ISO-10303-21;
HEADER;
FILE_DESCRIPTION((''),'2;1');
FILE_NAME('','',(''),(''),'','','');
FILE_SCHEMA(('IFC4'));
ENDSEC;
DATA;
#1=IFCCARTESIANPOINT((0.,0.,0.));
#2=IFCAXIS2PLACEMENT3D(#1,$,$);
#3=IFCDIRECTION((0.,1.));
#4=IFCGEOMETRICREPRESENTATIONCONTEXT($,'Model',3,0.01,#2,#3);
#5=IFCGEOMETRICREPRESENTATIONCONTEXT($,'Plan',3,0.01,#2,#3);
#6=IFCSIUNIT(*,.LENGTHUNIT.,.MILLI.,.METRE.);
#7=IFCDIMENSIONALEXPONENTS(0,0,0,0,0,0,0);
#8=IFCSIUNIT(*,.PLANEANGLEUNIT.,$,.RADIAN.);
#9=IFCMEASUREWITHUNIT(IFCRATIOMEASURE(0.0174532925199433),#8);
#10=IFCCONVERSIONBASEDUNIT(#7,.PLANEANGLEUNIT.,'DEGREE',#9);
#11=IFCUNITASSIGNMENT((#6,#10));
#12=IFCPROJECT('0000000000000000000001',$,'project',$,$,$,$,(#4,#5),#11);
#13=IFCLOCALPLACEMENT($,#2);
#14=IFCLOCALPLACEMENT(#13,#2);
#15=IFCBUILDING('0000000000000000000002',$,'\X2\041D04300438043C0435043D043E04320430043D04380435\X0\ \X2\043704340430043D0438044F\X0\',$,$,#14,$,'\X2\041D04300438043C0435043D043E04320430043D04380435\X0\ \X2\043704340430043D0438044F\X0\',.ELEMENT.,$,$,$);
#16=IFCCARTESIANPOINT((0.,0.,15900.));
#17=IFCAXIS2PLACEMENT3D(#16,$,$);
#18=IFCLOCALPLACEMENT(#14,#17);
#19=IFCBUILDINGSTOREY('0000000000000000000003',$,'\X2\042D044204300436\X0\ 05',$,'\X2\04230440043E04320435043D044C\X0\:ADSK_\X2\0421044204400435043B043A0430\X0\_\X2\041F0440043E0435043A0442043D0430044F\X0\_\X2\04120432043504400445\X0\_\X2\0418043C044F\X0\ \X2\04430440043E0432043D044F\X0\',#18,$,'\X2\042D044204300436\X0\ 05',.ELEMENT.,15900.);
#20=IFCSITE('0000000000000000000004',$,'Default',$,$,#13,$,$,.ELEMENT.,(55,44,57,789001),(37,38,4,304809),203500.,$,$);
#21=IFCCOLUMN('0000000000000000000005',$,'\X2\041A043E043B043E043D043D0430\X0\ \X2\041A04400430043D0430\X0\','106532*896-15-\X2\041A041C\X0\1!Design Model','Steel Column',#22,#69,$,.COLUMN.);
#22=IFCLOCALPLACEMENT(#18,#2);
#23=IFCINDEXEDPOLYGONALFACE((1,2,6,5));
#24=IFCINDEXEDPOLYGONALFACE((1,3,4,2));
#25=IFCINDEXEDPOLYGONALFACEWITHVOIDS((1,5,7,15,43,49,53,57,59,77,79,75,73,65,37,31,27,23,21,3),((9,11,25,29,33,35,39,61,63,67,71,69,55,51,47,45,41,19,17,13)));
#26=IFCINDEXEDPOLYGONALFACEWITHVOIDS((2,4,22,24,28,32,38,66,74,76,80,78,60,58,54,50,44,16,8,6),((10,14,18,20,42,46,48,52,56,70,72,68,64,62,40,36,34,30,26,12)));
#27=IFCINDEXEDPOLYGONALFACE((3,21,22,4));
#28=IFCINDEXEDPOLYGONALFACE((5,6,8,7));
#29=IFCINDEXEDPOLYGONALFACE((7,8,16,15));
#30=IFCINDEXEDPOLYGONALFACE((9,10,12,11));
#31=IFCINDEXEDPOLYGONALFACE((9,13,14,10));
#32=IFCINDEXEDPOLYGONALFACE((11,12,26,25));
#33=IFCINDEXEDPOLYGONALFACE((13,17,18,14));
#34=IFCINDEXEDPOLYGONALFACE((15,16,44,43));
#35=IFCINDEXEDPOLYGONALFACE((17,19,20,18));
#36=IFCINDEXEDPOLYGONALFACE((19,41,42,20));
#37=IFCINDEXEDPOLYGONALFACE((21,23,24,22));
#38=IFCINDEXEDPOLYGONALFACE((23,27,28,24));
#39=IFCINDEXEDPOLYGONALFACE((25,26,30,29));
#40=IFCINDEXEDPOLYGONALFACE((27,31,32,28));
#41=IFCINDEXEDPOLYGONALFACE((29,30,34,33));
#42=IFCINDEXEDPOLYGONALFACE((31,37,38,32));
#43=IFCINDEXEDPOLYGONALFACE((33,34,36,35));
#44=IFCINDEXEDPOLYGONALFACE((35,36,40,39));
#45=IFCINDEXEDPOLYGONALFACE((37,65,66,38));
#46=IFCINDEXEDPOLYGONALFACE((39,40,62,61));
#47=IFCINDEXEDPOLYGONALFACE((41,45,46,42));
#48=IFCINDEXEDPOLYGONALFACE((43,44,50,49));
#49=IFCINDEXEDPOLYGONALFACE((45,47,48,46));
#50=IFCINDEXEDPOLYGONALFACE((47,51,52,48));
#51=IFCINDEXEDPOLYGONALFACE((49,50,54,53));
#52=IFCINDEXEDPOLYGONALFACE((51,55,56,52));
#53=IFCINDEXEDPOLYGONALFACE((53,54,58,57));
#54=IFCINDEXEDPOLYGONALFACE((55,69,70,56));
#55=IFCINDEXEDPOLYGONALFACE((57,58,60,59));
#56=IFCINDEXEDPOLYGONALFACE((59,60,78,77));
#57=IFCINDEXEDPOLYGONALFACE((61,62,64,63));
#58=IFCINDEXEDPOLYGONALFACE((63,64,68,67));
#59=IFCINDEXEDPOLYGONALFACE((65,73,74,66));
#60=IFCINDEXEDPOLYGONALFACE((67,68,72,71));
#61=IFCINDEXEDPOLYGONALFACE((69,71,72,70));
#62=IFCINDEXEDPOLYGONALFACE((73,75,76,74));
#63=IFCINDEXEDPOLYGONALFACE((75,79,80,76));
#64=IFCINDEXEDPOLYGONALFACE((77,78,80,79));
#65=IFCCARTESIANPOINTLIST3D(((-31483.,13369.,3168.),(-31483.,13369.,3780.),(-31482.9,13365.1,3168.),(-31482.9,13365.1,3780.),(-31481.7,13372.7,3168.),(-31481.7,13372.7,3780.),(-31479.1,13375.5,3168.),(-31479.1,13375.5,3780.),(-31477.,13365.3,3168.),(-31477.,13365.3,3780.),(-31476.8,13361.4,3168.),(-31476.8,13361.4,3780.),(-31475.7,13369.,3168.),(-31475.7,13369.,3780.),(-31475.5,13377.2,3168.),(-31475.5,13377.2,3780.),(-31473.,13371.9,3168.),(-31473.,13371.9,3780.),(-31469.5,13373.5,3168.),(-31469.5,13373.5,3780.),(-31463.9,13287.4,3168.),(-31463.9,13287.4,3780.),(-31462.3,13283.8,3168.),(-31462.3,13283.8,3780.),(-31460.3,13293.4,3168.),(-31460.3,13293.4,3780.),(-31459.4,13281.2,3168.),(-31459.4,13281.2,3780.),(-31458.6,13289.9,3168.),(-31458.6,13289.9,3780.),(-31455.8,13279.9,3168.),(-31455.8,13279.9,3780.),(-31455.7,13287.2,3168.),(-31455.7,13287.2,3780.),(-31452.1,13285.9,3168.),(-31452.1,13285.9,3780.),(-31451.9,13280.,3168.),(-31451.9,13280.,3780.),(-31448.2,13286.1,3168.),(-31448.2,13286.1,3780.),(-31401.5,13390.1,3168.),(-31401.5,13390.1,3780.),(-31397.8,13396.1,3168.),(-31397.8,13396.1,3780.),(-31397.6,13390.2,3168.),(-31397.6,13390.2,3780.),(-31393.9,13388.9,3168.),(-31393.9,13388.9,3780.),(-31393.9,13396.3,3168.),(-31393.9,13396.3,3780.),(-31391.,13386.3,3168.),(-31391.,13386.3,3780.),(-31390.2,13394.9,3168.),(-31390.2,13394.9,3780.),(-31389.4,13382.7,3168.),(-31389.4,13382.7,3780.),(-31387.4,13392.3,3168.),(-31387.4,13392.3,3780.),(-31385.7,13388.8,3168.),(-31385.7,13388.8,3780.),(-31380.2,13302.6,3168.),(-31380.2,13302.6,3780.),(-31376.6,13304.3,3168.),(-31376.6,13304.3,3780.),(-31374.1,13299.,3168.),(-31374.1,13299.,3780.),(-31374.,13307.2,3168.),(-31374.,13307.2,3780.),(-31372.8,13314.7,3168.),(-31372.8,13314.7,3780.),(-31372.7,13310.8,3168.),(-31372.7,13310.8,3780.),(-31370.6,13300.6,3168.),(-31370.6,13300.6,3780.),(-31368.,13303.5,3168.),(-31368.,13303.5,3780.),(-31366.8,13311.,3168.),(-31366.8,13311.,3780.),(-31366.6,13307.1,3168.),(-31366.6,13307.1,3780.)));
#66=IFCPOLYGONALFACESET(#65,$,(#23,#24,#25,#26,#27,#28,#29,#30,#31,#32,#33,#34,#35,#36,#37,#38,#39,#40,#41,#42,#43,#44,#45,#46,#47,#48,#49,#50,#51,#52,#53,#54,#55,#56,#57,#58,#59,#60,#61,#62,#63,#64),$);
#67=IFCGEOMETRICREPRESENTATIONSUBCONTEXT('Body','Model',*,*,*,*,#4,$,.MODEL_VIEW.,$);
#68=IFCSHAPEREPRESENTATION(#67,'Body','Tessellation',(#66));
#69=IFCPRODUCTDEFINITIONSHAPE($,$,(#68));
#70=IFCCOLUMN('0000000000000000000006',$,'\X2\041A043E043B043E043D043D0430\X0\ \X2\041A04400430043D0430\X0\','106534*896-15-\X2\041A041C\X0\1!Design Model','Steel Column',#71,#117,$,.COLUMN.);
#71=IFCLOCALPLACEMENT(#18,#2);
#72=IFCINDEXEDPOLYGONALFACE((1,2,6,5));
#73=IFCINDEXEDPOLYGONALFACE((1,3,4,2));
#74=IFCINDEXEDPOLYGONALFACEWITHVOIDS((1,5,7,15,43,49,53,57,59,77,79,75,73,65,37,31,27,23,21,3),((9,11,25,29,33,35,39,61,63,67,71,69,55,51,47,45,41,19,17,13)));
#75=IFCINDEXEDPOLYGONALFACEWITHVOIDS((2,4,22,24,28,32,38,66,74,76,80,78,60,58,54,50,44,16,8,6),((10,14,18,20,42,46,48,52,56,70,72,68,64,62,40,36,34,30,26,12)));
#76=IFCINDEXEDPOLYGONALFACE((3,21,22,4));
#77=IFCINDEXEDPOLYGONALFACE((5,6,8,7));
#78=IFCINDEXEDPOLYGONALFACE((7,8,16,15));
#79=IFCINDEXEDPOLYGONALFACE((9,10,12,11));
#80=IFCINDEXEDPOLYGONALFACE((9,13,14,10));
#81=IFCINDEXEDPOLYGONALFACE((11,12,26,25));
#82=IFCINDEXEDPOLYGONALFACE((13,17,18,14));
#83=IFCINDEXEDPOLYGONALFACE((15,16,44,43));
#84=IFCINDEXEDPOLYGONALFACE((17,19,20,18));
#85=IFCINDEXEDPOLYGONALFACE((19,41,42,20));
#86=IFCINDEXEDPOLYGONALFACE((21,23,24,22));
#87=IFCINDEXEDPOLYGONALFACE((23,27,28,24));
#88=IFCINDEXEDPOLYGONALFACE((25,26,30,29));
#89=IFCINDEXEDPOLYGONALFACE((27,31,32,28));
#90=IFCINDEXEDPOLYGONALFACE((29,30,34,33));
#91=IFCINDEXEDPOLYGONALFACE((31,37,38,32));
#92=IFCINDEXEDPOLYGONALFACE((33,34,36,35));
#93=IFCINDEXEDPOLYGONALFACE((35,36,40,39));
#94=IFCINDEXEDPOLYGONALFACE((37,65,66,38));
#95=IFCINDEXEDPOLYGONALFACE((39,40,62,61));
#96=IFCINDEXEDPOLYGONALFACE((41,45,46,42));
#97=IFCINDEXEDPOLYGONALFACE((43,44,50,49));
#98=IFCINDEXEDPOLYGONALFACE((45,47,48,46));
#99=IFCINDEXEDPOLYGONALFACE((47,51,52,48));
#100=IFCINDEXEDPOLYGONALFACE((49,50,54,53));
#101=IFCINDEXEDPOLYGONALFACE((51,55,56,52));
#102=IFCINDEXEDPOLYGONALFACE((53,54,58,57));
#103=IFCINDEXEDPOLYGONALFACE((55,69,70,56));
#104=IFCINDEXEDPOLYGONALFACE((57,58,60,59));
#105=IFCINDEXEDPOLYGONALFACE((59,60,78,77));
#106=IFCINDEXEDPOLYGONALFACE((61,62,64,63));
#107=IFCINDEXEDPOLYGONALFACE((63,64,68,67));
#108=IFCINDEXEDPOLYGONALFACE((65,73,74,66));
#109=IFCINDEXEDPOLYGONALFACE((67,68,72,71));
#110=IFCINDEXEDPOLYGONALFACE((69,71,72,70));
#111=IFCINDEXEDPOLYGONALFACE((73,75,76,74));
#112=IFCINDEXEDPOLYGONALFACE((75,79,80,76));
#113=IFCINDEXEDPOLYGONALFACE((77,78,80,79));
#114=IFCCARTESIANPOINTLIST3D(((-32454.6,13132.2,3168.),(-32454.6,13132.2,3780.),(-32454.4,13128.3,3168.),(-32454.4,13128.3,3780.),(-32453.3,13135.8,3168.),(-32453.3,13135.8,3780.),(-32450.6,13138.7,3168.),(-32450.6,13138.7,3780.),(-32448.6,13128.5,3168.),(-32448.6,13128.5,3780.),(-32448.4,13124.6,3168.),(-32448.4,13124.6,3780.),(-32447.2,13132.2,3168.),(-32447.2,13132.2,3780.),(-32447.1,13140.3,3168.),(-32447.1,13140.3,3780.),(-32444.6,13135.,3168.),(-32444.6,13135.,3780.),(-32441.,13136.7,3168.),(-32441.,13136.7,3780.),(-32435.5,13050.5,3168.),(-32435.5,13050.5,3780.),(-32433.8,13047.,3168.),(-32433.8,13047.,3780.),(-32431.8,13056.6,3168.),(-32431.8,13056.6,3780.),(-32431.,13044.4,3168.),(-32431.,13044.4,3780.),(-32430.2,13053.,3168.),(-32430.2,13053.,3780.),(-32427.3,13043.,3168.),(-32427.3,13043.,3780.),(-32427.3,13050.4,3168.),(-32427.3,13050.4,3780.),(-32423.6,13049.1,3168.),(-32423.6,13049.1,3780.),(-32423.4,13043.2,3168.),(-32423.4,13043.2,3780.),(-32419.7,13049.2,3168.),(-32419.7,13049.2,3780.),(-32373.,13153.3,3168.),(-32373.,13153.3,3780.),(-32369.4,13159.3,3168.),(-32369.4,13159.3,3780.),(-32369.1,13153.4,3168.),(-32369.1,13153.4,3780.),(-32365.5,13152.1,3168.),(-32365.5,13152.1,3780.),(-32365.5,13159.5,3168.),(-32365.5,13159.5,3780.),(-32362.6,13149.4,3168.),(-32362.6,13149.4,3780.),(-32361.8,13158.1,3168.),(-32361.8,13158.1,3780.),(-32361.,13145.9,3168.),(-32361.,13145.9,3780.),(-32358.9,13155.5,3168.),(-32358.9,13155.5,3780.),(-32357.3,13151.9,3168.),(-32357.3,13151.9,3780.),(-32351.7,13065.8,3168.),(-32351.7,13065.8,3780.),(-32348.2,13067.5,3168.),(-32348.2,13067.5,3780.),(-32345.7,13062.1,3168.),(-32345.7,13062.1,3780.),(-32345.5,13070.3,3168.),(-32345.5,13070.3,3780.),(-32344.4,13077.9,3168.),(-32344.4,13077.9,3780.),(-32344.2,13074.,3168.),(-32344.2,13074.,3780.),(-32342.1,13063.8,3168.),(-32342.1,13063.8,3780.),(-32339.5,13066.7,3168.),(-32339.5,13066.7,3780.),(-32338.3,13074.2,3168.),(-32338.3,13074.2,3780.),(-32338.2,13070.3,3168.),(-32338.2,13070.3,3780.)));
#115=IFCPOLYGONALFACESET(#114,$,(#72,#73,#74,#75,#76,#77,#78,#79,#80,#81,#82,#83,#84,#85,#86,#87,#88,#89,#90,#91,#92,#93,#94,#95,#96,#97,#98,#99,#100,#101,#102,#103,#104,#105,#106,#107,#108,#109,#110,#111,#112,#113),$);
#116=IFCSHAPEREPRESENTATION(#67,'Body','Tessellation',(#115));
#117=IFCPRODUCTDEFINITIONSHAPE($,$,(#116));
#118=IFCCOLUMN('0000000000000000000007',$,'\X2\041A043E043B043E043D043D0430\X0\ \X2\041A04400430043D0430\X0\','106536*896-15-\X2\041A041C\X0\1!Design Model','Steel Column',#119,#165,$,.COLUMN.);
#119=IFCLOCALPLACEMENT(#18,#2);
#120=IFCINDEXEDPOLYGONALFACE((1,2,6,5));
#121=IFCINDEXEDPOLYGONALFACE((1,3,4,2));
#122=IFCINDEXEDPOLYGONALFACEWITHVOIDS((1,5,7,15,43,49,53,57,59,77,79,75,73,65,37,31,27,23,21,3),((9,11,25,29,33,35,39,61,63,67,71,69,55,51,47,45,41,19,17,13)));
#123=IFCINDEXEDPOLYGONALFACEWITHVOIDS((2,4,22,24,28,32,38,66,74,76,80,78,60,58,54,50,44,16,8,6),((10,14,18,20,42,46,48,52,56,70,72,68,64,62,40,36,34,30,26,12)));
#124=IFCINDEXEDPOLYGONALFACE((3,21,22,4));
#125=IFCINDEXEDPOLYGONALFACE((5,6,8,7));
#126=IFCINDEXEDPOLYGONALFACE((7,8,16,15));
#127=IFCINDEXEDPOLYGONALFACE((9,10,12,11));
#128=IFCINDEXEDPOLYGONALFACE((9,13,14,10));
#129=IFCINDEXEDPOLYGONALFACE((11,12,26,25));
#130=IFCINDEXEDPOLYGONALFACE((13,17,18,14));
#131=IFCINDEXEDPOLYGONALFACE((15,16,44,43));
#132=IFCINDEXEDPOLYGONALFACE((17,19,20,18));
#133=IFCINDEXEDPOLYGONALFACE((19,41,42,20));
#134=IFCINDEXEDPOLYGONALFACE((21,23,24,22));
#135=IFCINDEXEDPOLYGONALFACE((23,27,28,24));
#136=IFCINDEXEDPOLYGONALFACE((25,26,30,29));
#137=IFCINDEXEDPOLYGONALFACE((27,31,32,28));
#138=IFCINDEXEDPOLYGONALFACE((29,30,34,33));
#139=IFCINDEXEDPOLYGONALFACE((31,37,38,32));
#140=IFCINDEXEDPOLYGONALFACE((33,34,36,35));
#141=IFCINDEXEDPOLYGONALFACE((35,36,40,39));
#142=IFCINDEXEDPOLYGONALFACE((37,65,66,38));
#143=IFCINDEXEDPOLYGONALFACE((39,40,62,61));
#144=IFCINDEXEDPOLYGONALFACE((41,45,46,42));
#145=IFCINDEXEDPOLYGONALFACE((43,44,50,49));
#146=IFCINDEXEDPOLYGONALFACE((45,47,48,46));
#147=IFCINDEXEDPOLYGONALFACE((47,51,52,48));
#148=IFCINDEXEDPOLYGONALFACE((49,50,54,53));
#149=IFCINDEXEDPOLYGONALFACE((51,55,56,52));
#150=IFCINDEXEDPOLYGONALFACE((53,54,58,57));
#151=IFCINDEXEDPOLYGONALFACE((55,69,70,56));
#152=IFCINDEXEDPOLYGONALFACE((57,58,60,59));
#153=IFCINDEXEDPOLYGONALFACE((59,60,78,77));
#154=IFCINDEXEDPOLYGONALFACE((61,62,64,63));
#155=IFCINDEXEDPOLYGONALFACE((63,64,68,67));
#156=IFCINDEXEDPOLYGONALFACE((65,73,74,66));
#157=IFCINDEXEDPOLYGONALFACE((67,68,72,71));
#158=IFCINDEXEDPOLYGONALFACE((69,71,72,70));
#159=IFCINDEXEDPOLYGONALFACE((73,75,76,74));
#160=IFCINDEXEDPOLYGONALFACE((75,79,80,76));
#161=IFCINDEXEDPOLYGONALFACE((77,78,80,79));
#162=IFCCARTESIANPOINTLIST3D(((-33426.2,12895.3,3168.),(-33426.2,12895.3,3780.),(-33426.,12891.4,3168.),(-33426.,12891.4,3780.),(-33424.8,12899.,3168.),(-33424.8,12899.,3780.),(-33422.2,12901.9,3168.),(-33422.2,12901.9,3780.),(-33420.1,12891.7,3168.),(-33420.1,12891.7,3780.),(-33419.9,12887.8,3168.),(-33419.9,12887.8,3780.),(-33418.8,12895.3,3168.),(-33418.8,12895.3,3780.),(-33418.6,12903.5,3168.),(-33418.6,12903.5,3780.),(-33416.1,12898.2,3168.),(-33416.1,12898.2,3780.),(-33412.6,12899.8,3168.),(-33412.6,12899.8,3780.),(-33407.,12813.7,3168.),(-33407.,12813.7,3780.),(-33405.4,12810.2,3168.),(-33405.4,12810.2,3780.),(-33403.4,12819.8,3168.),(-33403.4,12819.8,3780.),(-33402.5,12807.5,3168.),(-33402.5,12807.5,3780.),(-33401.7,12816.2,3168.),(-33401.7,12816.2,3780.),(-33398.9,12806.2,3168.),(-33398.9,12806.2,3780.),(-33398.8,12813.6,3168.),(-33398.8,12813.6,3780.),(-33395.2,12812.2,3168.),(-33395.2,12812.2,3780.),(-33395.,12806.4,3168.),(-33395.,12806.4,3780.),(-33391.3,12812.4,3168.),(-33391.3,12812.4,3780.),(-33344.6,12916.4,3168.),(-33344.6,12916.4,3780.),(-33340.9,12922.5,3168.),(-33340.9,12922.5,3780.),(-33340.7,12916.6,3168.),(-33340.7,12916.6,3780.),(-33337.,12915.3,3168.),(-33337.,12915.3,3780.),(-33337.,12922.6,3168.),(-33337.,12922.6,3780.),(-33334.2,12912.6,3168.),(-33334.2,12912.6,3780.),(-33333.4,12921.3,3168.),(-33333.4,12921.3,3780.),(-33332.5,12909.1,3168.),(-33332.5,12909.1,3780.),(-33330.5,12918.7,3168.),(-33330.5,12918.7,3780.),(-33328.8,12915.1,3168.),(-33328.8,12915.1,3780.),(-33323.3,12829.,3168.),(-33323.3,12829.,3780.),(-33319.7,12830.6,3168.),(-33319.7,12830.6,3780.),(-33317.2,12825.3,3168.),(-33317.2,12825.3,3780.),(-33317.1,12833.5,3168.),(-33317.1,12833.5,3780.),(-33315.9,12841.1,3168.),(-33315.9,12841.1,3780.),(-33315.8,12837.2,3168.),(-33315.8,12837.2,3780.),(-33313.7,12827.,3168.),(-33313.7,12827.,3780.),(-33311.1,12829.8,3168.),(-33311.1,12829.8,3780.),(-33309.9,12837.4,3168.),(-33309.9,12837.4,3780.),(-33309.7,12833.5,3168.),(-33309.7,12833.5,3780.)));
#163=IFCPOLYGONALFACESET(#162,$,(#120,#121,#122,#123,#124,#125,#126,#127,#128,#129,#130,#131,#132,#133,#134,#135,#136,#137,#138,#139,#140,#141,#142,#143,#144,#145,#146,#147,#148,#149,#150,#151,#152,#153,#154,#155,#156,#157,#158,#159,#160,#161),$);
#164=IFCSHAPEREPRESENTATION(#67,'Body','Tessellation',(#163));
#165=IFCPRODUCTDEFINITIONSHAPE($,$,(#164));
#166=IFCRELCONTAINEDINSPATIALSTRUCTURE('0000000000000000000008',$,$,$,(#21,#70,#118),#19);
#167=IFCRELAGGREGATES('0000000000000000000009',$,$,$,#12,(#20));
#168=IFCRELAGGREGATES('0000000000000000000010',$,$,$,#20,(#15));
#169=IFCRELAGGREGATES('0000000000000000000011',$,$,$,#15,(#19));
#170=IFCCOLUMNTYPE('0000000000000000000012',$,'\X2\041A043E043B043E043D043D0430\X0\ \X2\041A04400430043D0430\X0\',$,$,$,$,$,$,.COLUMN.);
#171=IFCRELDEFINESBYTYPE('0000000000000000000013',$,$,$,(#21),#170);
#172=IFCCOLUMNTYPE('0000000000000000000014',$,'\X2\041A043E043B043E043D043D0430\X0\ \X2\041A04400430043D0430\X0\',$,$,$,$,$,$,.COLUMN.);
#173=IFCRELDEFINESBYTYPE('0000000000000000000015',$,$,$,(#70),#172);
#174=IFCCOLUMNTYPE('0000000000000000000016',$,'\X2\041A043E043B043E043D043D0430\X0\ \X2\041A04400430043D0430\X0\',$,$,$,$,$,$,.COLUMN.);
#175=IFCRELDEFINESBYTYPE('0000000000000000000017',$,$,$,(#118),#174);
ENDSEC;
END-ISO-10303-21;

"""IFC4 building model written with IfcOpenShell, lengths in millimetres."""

from ifc_helpers import new_model, entity, si_unit, converted_unit, direction, frame, origin, place, context, subcontext, project, spatial, indexed_curve, outline, extrude, type_object, element, save


model = new_model("IFC4")

# Units and contexts
model_context = context("Model", 3, precision=0.01, world=origin(), true_north=direction((0.0, 1.0)))
plan_context = context("Plan", 3, precision=0.01, world=origin(), true_north=direction((0.0, 1.0)))
body_context = subcontext(model_context, "Body", "Model", "MODEL_VIEW")
ifc_project = project(units=[si_unit("LENGTHUNIT", "METRE", prefix="MILLI"), converted_unit("PLANEANGLEUNIT", "DEGREE", entity("IfcRatioMeasure", 0.0174532925199433), si_unit("PLANEANGLEUNIT", "RADIAN"), dimensions=[0, 0, 0, 0, 0, 0, 0])], contexts=[model_context, plan_context])

# Site, building, storey
site_placement = place(None, origin())
site = spatial("IfcSite", under=ifc_project, at=site_placement, Name="Default", CompositionType="ELEMENT", RefLatitude=(55, 44, 57, 789001), RefLongitude=(37, 38, 4, 304809), RefElevation=203500.0)
building_placement = place(site_placement, origin())
building = spatial("IfcBuilding", under=site, at=building_placement, Name="Наименование здания", LongName="Наименование здания", CompositionType="ELEMENT")
storey_placement = place(building_placement, frame((0.0, 0.0, 15900.0)))
storey = spatial("IfcBuildingStorey", under=building, at=storey_placement, Name="Этаж 05", ObjectType="Уровень:ADSK_Стрелка_Проектная_Вверх_Имя уровня", LongName="Этаж 05", CompositionType="ELEMENT", Elevation=15900.0)

# Columns
column_type_1 = type_object("IfcColumnType", Name="Колонна Крана", PredefinedType="COLUMN")
column_1_placement = place(storey_placement, origin())
element("IfcColumn", 1, at=column_1_placement, inside=storey, type_object=column_type_1, Name="Колонна Крана", Description="106532*896-15-КМ1!Design Model", ObjectType="Steel Column", PredefinedType="COLUMN", context=body_context, shape_type="SweptSolid", body=[
    extrude(outline(indexed_curve([(29.5, -56.8), (33.4, -56.8), (37.0, -55.3), (39.7, -52.6), (41.2, -49.0), (56.8, 29.5), (56.8, 33.4), (55.3, 37.0), (52.6, 39.7), (49.0, 41.2), (-29.5, 56.8), (-33.4, 56.8), (-37.0, 55.3), (-39.7, 52.6), (-41.2, 49.0), (-56.8, -29.5), (-56.8, -33.4), (-55.3, -37.0), (-52.6, -39.7), (-49.0, -41.2), (29.5, -56.8)], self_intersect=False), holes=[indexed_curve([(-43.1, -37.3), (-46.7, -35.8), (-49.5, -33.1), (-51.0, -29.5), (-51.0, -25.5), (-37.3, 43.1), (-35.8, 46.7), (-33.1, 49.5), (-29.5, 51.0), (-25.5, 51.0), (43.1, 37.3), (46.7, 35.8), (49.5, 33.1), (51.0, 29.5), (51.0, 25.5), (37.3, -43.1), (35.8, -46.7), (33.1, -49.5), (29.5, -51.0), (25.5, -51.0), (-43.1, -37.3)], self_intersect=False)]), frame((-31424.8, 13338.1, 3168.0), z_axis=(0.0, 0.0, 1.0), x_axis=(0.906681, 0.421816, 0.0)), (0.0, 0.0, 1.0), 612.0),
])
column_type_2 = type_object("IfcColumnType", Name="Колонна Крана", PredefinedType="COLUMN")
column_2_placement = place(storey_placement, origin())
element("IfcColumn", 2, at=column_2_placement, inside=storey, type_object=column_type_2, Name="Колонна Крана", Description="106534*896-15-КМ1!Design Model", ObjectType="Steel Column", PredefinedType="COLUMN", context=body_context, shape_type="SweptSolid", body=[
    extrude(outline(indexed_curve([(29.5, -56.8), (33.4, -56.8), (37.0, -55.3), (39.7, -52.6), (41.2, -49.0), (56.8, 29.5), (56.8, 33.4), (55.3, 37.0), (52.6, 39.7), (49.0, 41.2), (-29.5, 56.8), (-33.4, 56.8), (-37.0, 55.3), (-39.7, 52.6), (-41.2, 49.0), (-56.8, -29.5), (-56.8, -33.4), (-55.3, -37.0), (-52.6, -39.7), (-49.0, -41.2), (29.5, -56.8)], self_intersect=False), holes=[indexed_curve([(-43.1, -37.3), (-46.7, -35.8), (-49.5, -33.1), (-51.0, -29.5), (-51.0, -25.5), (-37.3, 43.1), (-35.8, 46.7), (-33.1, 49.5), (-29.5, 51.0), (-25.5, 51.0), (43.1, 37.3), (46.7, 35.8), (49.5, 33.1), (51.0, 29.5), (51.0, 25.5), (37.3, -43.1), (35.8, -46.7), (33.1, -49.5), (29.5, -51.0), (25.5, -51.0), (-43.1, -37.3)], self_intersect=False)]), frame((-32396.4, 13101.2, 3168.0), z_axis=(0.0, 0.0, 1.0), x_axis=(0.906681, 0.421816, 0.0)), (0.0, 0.0, 1.0), 612.0),
])
column_type_3 = type_object("IfcColumnType", Name="Колонна Крана", PredefinedType="COLUMN")
column_3_placement = place(storey_placement, origin())
element("IfcColumn", 3, at=column_3_placement, inside=storey, type_object=column_type_3, Name="Колонна Крана", Description="106536*896-15-КМ1!Design Model", ObjectType="Steel Column", PredefinedType="COLUMN", context=body_context, shape_type="SweptSolid", body=[
    extrude(outline(indexed_curve([(29.5, -56.8), (33.4, -56.8), (37.0, -55.3), (39.7, -52.6), (41.2, -49.0), (56.8, 29.5), (56.8, 33.4), (55.3, 37.0), (52.6, 39.7), (49.0, 41.2), (-29.5, 56.8), (-33.4, 56.8), (-37.0, 55.3), (-39.7, 52.6), (-41.2, 49.0), (-56.8, -29.5), (-56.8, -33.4), (-55.3, -37.0), (-52.6, -39.7), (-49.0, -41.2), (29.5, -56.8)], self_intersect=False), holes=[indexed_curve([(-43.1, -37.3), (-46.7, -35.8), (-49.5, -33.1), (-51.0, -29.5), (-51.0, -25.5), (-37.3, 43.1), (-35.8, 46.7), (-33.1, 49.5), (-29.5, 51.0), (-25.5, 51.0), (43.1, 37.3), (46.7, 35.8), (49.5, 33.1), (51.0, 29.5), (51.0, 25.5), (37.3, -43.1), (35.8, -46.7), (33.1, -49.5), (29.5, -51.0), (25.5, -51.0), (-43.1, -37.3)], self_intersect=False)]), frame((-33367.9, 12864.4, 3168.0), z_axis=(0.0, 0.0, 1.0), x_axis=(0.906681, 0.421816, 0.0)), (0.0, 0.0, 1.0), 612.0),
])

save(model, "model.ifc")
